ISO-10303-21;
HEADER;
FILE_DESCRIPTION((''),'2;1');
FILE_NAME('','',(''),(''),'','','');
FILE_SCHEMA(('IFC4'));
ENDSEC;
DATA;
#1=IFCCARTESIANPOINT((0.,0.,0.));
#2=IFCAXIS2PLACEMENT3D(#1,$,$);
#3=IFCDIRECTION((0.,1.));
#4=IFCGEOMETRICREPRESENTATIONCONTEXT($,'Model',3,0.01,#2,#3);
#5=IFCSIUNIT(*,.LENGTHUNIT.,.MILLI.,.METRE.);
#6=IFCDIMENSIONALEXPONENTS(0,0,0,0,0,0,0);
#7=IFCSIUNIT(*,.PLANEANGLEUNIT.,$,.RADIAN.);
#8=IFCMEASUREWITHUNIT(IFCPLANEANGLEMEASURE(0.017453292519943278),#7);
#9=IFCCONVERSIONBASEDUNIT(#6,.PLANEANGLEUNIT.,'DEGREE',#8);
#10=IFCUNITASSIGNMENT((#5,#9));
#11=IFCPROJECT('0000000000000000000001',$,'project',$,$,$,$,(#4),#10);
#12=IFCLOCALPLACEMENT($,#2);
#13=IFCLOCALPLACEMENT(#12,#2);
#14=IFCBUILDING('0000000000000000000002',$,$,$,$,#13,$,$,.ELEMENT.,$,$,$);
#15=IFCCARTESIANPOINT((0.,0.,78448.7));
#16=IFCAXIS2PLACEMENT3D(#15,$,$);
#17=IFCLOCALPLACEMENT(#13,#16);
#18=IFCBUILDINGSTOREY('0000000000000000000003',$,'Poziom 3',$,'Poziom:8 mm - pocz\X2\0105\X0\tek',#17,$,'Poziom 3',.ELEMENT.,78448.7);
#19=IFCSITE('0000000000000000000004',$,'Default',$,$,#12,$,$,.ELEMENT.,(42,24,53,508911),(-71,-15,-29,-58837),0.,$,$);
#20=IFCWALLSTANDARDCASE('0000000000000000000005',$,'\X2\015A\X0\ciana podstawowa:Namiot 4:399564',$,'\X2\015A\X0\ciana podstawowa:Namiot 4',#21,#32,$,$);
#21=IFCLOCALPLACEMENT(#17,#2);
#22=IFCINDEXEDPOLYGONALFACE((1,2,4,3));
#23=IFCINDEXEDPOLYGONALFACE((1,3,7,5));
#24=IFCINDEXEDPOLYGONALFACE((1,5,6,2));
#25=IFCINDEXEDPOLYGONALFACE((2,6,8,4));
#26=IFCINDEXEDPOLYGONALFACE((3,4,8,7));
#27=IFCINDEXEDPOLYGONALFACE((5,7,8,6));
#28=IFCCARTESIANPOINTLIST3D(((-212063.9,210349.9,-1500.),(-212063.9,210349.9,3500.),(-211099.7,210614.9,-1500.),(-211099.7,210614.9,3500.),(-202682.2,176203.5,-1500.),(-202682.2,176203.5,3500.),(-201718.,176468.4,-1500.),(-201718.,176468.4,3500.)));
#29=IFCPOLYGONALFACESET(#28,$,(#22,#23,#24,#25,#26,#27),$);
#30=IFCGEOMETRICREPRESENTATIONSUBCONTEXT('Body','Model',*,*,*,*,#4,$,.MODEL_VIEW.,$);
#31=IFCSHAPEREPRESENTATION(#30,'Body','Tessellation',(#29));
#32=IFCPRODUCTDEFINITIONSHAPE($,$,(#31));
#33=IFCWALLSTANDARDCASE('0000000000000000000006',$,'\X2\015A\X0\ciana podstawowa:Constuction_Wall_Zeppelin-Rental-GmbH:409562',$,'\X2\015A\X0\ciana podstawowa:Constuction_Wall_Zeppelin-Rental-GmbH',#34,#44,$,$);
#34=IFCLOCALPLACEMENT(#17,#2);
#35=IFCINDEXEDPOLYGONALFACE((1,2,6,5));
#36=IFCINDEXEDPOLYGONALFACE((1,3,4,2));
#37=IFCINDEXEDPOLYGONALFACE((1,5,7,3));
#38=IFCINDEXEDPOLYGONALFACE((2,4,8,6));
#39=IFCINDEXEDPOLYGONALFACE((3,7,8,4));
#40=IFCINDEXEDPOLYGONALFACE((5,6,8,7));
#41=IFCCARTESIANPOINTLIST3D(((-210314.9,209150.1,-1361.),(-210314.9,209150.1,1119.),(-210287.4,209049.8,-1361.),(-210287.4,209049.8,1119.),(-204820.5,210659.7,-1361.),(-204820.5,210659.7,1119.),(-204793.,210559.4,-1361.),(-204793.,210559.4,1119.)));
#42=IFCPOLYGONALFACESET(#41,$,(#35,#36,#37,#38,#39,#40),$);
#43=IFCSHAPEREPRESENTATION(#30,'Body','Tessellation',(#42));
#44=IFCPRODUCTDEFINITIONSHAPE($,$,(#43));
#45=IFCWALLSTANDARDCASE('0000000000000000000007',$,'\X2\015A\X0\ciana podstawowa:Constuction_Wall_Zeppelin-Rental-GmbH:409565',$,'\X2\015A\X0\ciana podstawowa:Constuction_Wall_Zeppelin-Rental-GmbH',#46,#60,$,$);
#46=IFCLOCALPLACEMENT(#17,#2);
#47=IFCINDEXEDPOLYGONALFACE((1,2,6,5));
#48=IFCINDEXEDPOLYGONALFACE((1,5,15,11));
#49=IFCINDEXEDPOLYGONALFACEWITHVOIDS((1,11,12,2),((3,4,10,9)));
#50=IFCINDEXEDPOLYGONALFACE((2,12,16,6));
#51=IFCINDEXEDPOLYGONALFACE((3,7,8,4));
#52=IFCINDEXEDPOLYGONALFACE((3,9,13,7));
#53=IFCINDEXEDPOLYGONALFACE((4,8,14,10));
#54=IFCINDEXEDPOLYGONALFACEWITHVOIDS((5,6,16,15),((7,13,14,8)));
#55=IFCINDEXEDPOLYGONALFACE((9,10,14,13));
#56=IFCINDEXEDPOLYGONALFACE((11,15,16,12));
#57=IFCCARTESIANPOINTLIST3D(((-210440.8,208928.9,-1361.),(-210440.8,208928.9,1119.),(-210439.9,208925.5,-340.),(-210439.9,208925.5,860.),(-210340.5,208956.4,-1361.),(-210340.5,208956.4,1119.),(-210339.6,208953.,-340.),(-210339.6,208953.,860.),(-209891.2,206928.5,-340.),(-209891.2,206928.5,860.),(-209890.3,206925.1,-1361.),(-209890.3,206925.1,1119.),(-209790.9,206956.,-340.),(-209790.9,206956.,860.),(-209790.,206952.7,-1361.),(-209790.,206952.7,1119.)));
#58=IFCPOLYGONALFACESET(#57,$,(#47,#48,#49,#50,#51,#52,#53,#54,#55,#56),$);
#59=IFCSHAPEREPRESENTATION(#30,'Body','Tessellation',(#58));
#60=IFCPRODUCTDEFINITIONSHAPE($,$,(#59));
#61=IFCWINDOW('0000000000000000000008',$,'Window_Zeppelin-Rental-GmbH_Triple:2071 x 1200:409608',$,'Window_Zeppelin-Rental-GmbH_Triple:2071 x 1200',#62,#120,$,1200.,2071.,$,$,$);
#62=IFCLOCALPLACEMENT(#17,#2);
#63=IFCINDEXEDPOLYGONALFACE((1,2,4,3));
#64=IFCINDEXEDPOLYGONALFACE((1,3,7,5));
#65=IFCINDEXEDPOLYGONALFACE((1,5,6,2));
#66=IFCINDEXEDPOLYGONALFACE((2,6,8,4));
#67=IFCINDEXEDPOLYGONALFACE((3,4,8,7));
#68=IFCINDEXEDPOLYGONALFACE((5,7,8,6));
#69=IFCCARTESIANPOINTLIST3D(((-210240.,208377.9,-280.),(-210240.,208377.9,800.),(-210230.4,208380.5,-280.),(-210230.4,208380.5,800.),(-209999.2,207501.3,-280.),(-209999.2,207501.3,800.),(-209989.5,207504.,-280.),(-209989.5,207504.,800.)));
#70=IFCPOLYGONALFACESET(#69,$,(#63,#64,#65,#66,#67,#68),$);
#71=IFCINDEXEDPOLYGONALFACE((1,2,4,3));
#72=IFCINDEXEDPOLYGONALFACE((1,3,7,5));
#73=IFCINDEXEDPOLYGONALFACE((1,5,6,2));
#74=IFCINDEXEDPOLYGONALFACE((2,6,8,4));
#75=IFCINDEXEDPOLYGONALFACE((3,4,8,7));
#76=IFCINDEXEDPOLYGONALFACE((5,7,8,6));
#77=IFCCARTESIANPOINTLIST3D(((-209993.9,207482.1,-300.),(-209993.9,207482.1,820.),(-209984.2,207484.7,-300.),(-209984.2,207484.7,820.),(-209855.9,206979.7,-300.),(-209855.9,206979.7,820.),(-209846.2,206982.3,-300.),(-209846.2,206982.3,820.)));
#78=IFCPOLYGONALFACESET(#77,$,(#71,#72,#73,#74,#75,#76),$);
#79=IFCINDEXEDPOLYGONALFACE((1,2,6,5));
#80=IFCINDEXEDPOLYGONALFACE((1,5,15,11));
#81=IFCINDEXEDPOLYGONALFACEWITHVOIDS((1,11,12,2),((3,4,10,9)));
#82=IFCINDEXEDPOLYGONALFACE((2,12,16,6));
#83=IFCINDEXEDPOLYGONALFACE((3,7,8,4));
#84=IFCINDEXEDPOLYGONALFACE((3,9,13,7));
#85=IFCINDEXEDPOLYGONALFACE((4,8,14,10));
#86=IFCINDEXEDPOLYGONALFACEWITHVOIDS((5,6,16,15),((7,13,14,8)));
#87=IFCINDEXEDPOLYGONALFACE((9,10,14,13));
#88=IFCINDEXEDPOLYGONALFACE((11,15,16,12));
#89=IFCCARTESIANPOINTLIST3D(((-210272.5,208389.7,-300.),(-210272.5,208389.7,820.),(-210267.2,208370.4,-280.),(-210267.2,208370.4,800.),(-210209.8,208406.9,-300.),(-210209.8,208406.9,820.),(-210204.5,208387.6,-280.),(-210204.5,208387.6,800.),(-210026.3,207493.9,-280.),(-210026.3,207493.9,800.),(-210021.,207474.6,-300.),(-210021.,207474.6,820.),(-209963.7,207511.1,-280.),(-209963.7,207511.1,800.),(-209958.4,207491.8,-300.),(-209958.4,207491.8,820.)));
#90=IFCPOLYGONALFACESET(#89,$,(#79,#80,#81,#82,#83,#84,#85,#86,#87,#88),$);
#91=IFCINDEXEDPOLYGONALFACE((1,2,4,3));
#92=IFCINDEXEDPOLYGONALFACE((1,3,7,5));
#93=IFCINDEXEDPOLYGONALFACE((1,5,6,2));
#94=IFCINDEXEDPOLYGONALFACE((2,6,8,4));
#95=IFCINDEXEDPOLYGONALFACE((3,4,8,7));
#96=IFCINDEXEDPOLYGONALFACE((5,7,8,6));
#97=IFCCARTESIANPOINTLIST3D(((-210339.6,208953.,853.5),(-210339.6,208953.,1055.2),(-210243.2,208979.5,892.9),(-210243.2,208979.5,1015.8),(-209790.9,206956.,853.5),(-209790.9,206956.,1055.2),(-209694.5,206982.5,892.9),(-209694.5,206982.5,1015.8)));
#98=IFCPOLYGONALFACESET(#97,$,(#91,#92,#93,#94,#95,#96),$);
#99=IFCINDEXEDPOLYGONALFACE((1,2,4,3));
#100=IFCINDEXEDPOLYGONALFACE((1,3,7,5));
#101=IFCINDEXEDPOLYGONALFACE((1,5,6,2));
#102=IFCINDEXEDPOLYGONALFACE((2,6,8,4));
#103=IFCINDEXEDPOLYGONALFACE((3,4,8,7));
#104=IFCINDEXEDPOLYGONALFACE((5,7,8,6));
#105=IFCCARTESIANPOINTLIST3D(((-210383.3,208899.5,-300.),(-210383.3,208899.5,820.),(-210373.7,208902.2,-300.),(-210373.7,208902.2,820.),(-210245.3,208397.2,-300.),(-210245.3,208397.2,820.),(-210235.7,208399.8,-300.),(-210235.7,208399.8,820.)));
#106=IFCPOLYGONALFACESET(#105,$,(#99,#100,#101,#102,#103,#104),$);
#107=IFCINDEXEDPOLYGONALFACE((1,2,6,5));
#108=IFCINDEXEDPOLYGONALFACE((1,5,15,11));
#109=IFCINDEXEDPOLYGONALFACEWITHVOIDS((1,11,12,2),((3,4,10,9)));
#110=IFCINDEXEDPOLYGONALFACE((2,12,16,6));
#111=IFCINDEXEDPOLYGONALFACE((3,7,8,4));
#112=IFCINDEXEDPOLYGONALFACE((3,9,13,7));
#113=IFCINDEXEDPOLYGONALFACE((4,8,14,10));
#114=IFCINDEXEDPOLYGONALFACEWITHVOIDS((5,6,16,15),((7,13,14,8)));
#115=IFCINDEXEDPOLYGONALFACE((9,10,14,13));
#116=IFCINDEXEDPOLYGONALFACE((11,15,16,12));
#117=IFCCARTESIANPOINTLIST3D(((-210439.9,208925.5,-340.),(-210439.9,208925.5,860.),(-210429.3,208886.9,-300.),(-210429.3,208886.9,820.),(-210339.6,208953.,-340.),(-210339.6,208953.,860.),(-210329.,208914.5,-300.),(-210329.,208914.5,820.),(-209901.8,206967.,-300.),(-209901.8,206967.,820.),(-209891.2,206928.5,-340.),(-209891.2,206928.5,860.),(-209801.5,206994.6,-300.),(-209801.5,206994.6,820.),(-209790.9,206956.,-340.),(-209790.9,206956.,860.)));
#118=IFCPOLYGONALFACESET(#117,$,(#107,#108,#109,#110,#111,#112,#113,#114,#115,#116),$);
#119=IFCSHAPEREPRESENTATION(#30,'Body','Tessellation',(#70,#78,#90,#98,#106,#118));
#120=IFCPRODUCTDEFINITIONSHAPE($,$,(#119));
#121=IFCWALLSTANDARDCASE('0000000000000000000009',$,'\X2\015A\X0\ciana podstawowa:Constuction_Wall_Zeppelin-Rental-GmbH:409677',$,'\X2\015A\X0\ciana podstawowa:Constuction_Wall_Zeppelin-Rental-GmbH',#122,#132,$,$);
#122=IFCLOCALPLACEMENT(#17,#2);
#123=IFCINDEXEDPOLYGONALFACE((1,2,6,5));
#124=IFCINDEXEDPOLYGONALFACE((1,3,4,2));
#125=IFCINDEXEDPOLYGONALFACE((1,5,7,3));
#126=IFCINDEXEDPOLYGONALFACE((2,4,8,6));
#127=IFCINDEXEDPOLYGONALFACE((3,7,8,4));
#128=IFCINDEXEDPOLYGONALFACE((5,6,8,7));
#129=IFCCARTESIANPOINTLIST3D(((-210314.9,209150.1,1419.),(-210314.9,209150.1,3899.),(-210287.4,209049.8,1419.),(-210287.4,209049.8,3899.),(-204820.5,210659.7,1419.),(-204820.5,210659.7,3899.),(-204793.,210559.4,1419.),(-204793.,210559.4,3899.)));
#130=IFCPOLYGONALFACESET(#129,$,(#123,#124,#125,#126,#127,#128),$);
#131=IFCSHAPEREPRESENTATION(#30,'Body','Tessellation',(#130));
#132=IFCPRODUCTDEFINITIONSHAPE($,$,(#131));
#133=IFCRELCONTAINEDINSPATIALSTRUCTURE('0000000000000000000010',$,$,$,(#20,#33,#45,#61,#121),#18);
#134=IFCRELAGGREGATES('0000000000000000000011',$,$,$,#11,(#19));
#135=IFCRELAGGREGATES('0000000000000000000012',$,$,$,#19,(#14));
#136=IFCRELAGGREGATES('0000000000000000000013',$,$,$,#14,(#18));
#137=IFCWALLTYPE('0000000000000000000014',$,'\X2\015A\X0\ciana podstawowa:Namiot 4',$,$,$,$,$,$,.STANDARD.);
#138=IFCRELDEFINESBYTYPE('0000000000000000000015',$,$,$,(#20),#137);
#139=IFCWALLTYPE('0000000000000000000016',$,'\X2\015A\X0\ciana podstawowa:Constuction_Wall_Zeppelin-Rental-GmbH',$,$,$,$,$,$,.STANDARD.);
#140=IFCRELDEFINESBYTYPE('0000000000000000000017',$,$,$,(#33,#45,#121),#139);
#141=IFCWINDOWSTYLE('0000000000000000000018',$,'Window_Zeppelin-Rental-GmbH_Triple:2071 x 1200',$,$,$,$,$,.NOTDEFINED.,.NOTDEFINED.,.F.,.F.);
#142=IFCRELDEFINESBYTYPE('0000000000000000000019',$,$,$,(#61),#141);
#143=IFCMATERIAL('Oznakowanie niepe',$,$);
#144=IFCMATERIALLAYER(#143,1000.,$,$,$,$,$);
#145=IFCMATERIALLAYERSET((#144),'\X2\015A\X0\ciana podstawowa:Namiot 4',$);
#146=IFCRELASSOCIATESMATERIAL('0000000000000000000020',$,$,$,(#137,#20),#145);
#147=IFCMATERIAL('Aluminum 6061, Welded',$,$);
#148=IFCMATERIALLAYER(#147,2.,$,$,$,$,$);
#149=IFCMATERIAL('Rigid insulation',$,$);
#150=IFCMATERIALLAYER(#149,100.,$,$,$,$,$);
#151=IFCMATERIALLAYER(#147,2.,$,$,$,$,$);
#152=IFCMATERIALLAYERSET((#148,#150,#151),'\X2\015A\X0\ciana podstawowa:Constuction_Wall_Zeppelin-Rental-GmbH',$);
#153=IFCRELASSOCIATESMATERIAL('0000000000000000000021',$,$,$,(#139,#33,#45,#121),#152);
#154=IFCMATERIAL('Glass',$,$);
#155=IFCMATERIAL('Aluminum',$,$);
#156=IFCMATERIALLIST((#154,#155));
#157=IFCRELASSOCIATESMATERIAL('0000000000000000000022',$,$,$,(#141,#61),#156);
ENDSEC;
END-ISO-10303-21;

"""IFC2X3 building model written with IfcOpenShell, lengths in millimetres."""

from ifc_helpers import new_model, entity, si_unit, converted_unit, direction, frame, frame_2d, origin, origin_2d_with_axis, place, context, subcontext, project, spatial, polyline, rectangle, outline, extrude, source, transform, mapped, material, material_list, layer, layer_set, layer_usage, type_object, type_shapes, element, fill, save


model = new_model("IFC2X3")

# Units and contexts
model_context = context("Model", 3, precision=0.01, world=origin(), true_north=direction((0.0, 1.0)))
body_context = subcontext(model_context, "Body", "Model", "MODEL_VIEW")
ifc_project = project(units=[si_unit("LENGTHUNIT", "METRE", prefix="MILLI"), converted_unit("PLANEANGLEUNIT", "DEGREE", entity("IfcPlaneAngleMeasure", 0.017453292519943278), si_unit("PLANEANGLEUNIT", "RADIAN"), dimensions=[0, 0, 0, 0, 0, 0, 0])], contexts=[model_context])

# Site, building, storey
site_placement = place(None, origin())
site = spatial("IfcSite", under=ifc_project, at=site_placement, Name="Default", CompositionType="ELEMENT", RefLatitude=(42, 24, 53, 508911), RefLongitude=(-71, -15, -29, -58837), RefElevation=0.0)
building_placement = place(site_placement, origin())
building = spatial("IfcBuilding", under=site, at=building_placement, CompositionType="ELEMENT")
storey_placement = place(building_placement, frame((0.0, 0.0, 78448.7)))
storey = spatial("IfcBuildingStorey", under=building, at=storey_placement, Name="Poziom 3", ObjectType="Poziom:8 mm - początek", LongName="Poziom 3", CompositionType="ELEMENT", Elevation=78448.7)

# Walls
ifc_material_1 = material(Name="Oznakowanie niepe")
ifc_layer_1 = layer(ifc_material_1, 1000.0)
ifc_layer_set_1 = layer_set([ifc_layer_1], Name="Ściana podstawowa:Namiot 4")
ifc_layer_usage_1 = layer_usage(ifc_layer_set_1, "AXIS2", "NEGATIVE", 500.0)
wall_type_1 = type_object("IfcWallType", Name="Ściana podstawowa:Namiot 4", PredefinedType="STANDARD", material=ifc_layer_set_1)
wall_1_placement = place(storey_placement, frame((-211581.8, 210482.4, -1500.0), z_axis=(0.0, 0.0, 1.0), x_axis=(0.264931, -0.964267, 0.0)))
element("IfcWallStandardCase", 1, at=wall_1_placement, inside=storey, type_object=wall_type_1, material=ifc_layer_usage_1, Name="Ściana podstawowa:Namiot 4:399564", ObjectType="Ściana podstawowa:Namiot 4", context=body_context, shape_type="SweptSolid", body=[
    extrude(rectangle(XDim=35411.8, YDim=1000.0, at=frame_2d((17705.9, 0.0), x_axis=(-1.0, 0.0))), origin(), (0.0, 0.0, 1.0), 5000.0),
])
ifc_material_2 = material(Name="Aluminum 6061, Welded")
ifc_layer_2 = layer(ifc_material_2, 2.0)
ifc_material_3 = material(Name="Rigid insulation")
ifc_layer_3 = layer(ifc_material_3, 100.0)
ifc_layer_4 = layer(ifc_material_2, 2.0)
ifc_layer_set_2 = layer_set([ifc_layer_2, ifc_layer_3, ifc_layer_4], Name="Ściana podstawowa:Constuction_Wall_Zeppelin-Rental-GmbH")
ifc_layer_usage_2 = layer_usage(ifc_layer_set_2, "AXIS2", "NEGATIVE", 52.0)
wall_type_2 = type_object("IfcWallType", Name="Ściana podstawowa:Constuction_Wall_Zeppelin-Rental-GmbH", PredefinedType="STANDARD", material=ifc_layer_set_2)
wall_2_placement = place(storey_placement, frame((-210301.2, 209100.0, -1361.0), z_axis=(0.0, 0.0, 1.0), x_axis=(0.964267, 0.264931, 0.0)))
element("IfcWallStandardCase", 2, at=wall_2_placement, inside=storey, type_object=wall_type_2, material=ifc_layer_usage_2, Name="Ściana podstawowa:Constuction_Wall_Zeppelin-Rental-GmbH:409562", ObjectType="Ściana podstawowa:Constuction_Wall_Zeppelin-Rental-GmbH", context=body_context, shape_type="SweptSolid", body=[
    extrude(rectangle(XDim=5698.0, YDim=104.0, at=frame_2d((2849.0, 0.0), x_axis=(-1.0, 0.0))), origin(), (0.0, 0.0, 1.0), 2480.0),
])

# Wall, opening, window
ifc_layer_usage_3 = layer_usage(ifc_layer_set_2, "AXIS2", "NEGATIVE", 52.0)
wall_3_placement = place(storey_placement, frame((-209840.2, 206938.9, -1361.0), z_axis=(0.0, 0.0, 1.0), x_axis=(-0.264931, 0.964267, 0.0)))
wall_3 = element("IfcWallStandardCase", 3, at=wall_3_placement, inside=storey, type_object=wall_type_2, material=ifc_layer_usage_3, Name="Ściana podstawowa:Constuction_Wall_Zeppelin-Rental-GmbH:409565", ObjectType="Ściana podstawowa:Constuction_Wall_Zeppelin-Rental-GmbH", context=body_context, shape_type="SweptSolid", body=[
    extrude(rectangle(XDim=2078.0, YDim=104.0, at=frame_2d((1039.0, 0.0), x_axis=(-1.0, 0.0))), origin(), (0.0, 0.0, 1.0), 2480.0),
])
opening_1_placement = place(wall_3_placement, frame((3.5, -52.0, 1021.0)))
opening_1 = element("IfcOpeningElement", 4, at=opening_1_placement, cuts=wall_3, ObjectType="Opening", context=body_context, shape_type="SweptSolid", body=[
    extrude(rectangle(XDim=1200.0, YDim=2071.0, at=frame_2d((600.0, 1035.5), x_axis=(1.0, 0.0))), frame((0.0, 0.0, 0.0), z_axis=(0.0, 1.0, 0.0), x_axis=(0.0, 0.0, 1.0)), (0.0, 0.0, 1.0), 104.0),
])
ifc_material_4 = material(Name="Glass")
ifc_material_5 = material(Name="Aluminum")
ifc_material_list = material_list([ifc_material_4, ifc_material_5])
window_style = type_object("IfcWindowStyle", Name="Window_Zeppelin-Rental-GmbH_Triple:2071 x 1200", ConstructionType="NOTDEFINED", OperationType="NOTDEFINED", ParameterTakesPrecedence=False, Sizeable=False, material=ifc_material_list)
shared_shape_1 = source(origin(), body_context, "Body", "SweptSolid", [
    extrude(rectangle(XDim=10.0, YDim=909.0, at=origin_2d_with_axis()), frame((1035.5, 52.7, 60.0), z_axis=(0.0, 0.0, 1.0), x_axis=(0.0, -1.0, 0.0)), (0.0, 0.0, 1.0), 1080.0),
    extrude(rectangle(XDim=521.0, YDim=10.0, at=frame_2d((0.0, 0.0), x_axis=(1.0, 0.0))), frame((300.5, 52.7, 40.0), z_axis=(0.0, 0.0, 1.0), x_axis=(-1.0, 0.0, 0.0)), (0.0, 0.0, 1.0), 1120.0),
    extrude(outline(polyline([(-474.5, -560.0), (474.5, -560.0), (474.5, 560.0), (-474.5, 560.0), (-474.5, -560.0)]), holes=[polyline([(-454.5, 540.0), (454.5, 540.0), (454.5, -540.0), (-454.5, -540.0), (-454.5, 540.0)])]), frame((1035.5, 85.8, 600.0), z_axis=(0.0, -1.0, 0.0), x_axis=(1.0, 0.0, 0.0)), (0.0, 0.0, 1.0), 65.0),
    extrude(outline(polyline([(-24.0, -75.5), (83.5, -75.5), (9.6, 112.1), (-69.0, 38.9), (-24.0, -75.5)])), frame((2071.0, -48.7, 1294.4), z_axis=(-1.0, 0.0, 0.0), x_axis=(0.0, 0.930458, 0.366398)), (0.0, 0.0, 1.0), 2071.0),
    extrude(rectangle(XDim=10.0, YDim=521.0, at=frame_2d((0.0, 0.0), x_axis=(1.0, 0.0))), frame((1770.5, 52.7, 40.0), z_axis=(0.0, 0.0, 1.0), x_axis=(0.0, -1.0, 0.0)), (0.0, 0.0, 1.0), 1120.0),
    extrude(outline(polyline([(-1035.5, -600.0), (1035.5, -600.0), (1035.5, 600.0), (-1035.5, 600.0), (-1035.5, -600.0)]), holes=[polyline([(-995.5, 560.0), (995.5, 560.0), (995.5, -560.0), (-995.5, -560.0), (-995.5, 560.0)])]), frame((1035.5, 105.3, 600.0), z_axis=(0.0, -1.0, 0.0), x_axis=(1.0, 0.0, 0.0)), (0.0, 0.0, 1.0), 104.0),
])
type_shapes(window_style, [shared_shape_1])
window_1_placement = place(opening_1_placement, frame((0.0, -1.3, 0.0)))
window_1 = element("IfcWindow", 5, at=window_1_placement, inside=storey, type_object=window_style, material=ifc_material_list, Name="Window_Zeppelin-Rental-GmbH_Triple:2071 x 1200:409608", ObjectType="Window_Zeppelin-Rental-GmbH_Triple:2071 x 1200", OverallHeight=1200.0, OverallWidth=2071.0, context=body_context, shape_type="MappedRepresentation", body=[
    mapped(shared_shape_1, transform((0.0, 0.0, 0.0), scale=1.0)),
])
fill(opening_1, window_1)

# Wall
ifc_layer_usage_4 = layer_usage(ifc_layer_set_2, "AXIS2", "NEGATIVE", 52.0)
wall_4_placement = place(storey_placement, frame((-210301.2, 209100.0, 1419.0), z_axis=(0.0, 0.0, 1.0), x_axis=(0.964267, 0.264931, 0.0)))
element("IfcWallStandardCase", 6, at=wall_4_placement, inside=storey, type_object=wall_type_2, material=ifc_layer_usage_4, Name="Ściana podstawowa:Constuction_Wall_Zeppelin-Rental-GmbH:409677", ObjectType="Ściana podstawowa:Constuction_Wall_Zeppelin-Rental-GmbH", context=body_context, shape_type="SweptSolid", body=[
    extrude(rectangle(XDim=5698.0, YDim=104.0, at=frame_2d((2849.0, 0.0), x_axis=(-1.0, 0.0))), origin(), (0.0, 0.0, 1.0), 2480.0),
])

save(model, "model.ifc")
